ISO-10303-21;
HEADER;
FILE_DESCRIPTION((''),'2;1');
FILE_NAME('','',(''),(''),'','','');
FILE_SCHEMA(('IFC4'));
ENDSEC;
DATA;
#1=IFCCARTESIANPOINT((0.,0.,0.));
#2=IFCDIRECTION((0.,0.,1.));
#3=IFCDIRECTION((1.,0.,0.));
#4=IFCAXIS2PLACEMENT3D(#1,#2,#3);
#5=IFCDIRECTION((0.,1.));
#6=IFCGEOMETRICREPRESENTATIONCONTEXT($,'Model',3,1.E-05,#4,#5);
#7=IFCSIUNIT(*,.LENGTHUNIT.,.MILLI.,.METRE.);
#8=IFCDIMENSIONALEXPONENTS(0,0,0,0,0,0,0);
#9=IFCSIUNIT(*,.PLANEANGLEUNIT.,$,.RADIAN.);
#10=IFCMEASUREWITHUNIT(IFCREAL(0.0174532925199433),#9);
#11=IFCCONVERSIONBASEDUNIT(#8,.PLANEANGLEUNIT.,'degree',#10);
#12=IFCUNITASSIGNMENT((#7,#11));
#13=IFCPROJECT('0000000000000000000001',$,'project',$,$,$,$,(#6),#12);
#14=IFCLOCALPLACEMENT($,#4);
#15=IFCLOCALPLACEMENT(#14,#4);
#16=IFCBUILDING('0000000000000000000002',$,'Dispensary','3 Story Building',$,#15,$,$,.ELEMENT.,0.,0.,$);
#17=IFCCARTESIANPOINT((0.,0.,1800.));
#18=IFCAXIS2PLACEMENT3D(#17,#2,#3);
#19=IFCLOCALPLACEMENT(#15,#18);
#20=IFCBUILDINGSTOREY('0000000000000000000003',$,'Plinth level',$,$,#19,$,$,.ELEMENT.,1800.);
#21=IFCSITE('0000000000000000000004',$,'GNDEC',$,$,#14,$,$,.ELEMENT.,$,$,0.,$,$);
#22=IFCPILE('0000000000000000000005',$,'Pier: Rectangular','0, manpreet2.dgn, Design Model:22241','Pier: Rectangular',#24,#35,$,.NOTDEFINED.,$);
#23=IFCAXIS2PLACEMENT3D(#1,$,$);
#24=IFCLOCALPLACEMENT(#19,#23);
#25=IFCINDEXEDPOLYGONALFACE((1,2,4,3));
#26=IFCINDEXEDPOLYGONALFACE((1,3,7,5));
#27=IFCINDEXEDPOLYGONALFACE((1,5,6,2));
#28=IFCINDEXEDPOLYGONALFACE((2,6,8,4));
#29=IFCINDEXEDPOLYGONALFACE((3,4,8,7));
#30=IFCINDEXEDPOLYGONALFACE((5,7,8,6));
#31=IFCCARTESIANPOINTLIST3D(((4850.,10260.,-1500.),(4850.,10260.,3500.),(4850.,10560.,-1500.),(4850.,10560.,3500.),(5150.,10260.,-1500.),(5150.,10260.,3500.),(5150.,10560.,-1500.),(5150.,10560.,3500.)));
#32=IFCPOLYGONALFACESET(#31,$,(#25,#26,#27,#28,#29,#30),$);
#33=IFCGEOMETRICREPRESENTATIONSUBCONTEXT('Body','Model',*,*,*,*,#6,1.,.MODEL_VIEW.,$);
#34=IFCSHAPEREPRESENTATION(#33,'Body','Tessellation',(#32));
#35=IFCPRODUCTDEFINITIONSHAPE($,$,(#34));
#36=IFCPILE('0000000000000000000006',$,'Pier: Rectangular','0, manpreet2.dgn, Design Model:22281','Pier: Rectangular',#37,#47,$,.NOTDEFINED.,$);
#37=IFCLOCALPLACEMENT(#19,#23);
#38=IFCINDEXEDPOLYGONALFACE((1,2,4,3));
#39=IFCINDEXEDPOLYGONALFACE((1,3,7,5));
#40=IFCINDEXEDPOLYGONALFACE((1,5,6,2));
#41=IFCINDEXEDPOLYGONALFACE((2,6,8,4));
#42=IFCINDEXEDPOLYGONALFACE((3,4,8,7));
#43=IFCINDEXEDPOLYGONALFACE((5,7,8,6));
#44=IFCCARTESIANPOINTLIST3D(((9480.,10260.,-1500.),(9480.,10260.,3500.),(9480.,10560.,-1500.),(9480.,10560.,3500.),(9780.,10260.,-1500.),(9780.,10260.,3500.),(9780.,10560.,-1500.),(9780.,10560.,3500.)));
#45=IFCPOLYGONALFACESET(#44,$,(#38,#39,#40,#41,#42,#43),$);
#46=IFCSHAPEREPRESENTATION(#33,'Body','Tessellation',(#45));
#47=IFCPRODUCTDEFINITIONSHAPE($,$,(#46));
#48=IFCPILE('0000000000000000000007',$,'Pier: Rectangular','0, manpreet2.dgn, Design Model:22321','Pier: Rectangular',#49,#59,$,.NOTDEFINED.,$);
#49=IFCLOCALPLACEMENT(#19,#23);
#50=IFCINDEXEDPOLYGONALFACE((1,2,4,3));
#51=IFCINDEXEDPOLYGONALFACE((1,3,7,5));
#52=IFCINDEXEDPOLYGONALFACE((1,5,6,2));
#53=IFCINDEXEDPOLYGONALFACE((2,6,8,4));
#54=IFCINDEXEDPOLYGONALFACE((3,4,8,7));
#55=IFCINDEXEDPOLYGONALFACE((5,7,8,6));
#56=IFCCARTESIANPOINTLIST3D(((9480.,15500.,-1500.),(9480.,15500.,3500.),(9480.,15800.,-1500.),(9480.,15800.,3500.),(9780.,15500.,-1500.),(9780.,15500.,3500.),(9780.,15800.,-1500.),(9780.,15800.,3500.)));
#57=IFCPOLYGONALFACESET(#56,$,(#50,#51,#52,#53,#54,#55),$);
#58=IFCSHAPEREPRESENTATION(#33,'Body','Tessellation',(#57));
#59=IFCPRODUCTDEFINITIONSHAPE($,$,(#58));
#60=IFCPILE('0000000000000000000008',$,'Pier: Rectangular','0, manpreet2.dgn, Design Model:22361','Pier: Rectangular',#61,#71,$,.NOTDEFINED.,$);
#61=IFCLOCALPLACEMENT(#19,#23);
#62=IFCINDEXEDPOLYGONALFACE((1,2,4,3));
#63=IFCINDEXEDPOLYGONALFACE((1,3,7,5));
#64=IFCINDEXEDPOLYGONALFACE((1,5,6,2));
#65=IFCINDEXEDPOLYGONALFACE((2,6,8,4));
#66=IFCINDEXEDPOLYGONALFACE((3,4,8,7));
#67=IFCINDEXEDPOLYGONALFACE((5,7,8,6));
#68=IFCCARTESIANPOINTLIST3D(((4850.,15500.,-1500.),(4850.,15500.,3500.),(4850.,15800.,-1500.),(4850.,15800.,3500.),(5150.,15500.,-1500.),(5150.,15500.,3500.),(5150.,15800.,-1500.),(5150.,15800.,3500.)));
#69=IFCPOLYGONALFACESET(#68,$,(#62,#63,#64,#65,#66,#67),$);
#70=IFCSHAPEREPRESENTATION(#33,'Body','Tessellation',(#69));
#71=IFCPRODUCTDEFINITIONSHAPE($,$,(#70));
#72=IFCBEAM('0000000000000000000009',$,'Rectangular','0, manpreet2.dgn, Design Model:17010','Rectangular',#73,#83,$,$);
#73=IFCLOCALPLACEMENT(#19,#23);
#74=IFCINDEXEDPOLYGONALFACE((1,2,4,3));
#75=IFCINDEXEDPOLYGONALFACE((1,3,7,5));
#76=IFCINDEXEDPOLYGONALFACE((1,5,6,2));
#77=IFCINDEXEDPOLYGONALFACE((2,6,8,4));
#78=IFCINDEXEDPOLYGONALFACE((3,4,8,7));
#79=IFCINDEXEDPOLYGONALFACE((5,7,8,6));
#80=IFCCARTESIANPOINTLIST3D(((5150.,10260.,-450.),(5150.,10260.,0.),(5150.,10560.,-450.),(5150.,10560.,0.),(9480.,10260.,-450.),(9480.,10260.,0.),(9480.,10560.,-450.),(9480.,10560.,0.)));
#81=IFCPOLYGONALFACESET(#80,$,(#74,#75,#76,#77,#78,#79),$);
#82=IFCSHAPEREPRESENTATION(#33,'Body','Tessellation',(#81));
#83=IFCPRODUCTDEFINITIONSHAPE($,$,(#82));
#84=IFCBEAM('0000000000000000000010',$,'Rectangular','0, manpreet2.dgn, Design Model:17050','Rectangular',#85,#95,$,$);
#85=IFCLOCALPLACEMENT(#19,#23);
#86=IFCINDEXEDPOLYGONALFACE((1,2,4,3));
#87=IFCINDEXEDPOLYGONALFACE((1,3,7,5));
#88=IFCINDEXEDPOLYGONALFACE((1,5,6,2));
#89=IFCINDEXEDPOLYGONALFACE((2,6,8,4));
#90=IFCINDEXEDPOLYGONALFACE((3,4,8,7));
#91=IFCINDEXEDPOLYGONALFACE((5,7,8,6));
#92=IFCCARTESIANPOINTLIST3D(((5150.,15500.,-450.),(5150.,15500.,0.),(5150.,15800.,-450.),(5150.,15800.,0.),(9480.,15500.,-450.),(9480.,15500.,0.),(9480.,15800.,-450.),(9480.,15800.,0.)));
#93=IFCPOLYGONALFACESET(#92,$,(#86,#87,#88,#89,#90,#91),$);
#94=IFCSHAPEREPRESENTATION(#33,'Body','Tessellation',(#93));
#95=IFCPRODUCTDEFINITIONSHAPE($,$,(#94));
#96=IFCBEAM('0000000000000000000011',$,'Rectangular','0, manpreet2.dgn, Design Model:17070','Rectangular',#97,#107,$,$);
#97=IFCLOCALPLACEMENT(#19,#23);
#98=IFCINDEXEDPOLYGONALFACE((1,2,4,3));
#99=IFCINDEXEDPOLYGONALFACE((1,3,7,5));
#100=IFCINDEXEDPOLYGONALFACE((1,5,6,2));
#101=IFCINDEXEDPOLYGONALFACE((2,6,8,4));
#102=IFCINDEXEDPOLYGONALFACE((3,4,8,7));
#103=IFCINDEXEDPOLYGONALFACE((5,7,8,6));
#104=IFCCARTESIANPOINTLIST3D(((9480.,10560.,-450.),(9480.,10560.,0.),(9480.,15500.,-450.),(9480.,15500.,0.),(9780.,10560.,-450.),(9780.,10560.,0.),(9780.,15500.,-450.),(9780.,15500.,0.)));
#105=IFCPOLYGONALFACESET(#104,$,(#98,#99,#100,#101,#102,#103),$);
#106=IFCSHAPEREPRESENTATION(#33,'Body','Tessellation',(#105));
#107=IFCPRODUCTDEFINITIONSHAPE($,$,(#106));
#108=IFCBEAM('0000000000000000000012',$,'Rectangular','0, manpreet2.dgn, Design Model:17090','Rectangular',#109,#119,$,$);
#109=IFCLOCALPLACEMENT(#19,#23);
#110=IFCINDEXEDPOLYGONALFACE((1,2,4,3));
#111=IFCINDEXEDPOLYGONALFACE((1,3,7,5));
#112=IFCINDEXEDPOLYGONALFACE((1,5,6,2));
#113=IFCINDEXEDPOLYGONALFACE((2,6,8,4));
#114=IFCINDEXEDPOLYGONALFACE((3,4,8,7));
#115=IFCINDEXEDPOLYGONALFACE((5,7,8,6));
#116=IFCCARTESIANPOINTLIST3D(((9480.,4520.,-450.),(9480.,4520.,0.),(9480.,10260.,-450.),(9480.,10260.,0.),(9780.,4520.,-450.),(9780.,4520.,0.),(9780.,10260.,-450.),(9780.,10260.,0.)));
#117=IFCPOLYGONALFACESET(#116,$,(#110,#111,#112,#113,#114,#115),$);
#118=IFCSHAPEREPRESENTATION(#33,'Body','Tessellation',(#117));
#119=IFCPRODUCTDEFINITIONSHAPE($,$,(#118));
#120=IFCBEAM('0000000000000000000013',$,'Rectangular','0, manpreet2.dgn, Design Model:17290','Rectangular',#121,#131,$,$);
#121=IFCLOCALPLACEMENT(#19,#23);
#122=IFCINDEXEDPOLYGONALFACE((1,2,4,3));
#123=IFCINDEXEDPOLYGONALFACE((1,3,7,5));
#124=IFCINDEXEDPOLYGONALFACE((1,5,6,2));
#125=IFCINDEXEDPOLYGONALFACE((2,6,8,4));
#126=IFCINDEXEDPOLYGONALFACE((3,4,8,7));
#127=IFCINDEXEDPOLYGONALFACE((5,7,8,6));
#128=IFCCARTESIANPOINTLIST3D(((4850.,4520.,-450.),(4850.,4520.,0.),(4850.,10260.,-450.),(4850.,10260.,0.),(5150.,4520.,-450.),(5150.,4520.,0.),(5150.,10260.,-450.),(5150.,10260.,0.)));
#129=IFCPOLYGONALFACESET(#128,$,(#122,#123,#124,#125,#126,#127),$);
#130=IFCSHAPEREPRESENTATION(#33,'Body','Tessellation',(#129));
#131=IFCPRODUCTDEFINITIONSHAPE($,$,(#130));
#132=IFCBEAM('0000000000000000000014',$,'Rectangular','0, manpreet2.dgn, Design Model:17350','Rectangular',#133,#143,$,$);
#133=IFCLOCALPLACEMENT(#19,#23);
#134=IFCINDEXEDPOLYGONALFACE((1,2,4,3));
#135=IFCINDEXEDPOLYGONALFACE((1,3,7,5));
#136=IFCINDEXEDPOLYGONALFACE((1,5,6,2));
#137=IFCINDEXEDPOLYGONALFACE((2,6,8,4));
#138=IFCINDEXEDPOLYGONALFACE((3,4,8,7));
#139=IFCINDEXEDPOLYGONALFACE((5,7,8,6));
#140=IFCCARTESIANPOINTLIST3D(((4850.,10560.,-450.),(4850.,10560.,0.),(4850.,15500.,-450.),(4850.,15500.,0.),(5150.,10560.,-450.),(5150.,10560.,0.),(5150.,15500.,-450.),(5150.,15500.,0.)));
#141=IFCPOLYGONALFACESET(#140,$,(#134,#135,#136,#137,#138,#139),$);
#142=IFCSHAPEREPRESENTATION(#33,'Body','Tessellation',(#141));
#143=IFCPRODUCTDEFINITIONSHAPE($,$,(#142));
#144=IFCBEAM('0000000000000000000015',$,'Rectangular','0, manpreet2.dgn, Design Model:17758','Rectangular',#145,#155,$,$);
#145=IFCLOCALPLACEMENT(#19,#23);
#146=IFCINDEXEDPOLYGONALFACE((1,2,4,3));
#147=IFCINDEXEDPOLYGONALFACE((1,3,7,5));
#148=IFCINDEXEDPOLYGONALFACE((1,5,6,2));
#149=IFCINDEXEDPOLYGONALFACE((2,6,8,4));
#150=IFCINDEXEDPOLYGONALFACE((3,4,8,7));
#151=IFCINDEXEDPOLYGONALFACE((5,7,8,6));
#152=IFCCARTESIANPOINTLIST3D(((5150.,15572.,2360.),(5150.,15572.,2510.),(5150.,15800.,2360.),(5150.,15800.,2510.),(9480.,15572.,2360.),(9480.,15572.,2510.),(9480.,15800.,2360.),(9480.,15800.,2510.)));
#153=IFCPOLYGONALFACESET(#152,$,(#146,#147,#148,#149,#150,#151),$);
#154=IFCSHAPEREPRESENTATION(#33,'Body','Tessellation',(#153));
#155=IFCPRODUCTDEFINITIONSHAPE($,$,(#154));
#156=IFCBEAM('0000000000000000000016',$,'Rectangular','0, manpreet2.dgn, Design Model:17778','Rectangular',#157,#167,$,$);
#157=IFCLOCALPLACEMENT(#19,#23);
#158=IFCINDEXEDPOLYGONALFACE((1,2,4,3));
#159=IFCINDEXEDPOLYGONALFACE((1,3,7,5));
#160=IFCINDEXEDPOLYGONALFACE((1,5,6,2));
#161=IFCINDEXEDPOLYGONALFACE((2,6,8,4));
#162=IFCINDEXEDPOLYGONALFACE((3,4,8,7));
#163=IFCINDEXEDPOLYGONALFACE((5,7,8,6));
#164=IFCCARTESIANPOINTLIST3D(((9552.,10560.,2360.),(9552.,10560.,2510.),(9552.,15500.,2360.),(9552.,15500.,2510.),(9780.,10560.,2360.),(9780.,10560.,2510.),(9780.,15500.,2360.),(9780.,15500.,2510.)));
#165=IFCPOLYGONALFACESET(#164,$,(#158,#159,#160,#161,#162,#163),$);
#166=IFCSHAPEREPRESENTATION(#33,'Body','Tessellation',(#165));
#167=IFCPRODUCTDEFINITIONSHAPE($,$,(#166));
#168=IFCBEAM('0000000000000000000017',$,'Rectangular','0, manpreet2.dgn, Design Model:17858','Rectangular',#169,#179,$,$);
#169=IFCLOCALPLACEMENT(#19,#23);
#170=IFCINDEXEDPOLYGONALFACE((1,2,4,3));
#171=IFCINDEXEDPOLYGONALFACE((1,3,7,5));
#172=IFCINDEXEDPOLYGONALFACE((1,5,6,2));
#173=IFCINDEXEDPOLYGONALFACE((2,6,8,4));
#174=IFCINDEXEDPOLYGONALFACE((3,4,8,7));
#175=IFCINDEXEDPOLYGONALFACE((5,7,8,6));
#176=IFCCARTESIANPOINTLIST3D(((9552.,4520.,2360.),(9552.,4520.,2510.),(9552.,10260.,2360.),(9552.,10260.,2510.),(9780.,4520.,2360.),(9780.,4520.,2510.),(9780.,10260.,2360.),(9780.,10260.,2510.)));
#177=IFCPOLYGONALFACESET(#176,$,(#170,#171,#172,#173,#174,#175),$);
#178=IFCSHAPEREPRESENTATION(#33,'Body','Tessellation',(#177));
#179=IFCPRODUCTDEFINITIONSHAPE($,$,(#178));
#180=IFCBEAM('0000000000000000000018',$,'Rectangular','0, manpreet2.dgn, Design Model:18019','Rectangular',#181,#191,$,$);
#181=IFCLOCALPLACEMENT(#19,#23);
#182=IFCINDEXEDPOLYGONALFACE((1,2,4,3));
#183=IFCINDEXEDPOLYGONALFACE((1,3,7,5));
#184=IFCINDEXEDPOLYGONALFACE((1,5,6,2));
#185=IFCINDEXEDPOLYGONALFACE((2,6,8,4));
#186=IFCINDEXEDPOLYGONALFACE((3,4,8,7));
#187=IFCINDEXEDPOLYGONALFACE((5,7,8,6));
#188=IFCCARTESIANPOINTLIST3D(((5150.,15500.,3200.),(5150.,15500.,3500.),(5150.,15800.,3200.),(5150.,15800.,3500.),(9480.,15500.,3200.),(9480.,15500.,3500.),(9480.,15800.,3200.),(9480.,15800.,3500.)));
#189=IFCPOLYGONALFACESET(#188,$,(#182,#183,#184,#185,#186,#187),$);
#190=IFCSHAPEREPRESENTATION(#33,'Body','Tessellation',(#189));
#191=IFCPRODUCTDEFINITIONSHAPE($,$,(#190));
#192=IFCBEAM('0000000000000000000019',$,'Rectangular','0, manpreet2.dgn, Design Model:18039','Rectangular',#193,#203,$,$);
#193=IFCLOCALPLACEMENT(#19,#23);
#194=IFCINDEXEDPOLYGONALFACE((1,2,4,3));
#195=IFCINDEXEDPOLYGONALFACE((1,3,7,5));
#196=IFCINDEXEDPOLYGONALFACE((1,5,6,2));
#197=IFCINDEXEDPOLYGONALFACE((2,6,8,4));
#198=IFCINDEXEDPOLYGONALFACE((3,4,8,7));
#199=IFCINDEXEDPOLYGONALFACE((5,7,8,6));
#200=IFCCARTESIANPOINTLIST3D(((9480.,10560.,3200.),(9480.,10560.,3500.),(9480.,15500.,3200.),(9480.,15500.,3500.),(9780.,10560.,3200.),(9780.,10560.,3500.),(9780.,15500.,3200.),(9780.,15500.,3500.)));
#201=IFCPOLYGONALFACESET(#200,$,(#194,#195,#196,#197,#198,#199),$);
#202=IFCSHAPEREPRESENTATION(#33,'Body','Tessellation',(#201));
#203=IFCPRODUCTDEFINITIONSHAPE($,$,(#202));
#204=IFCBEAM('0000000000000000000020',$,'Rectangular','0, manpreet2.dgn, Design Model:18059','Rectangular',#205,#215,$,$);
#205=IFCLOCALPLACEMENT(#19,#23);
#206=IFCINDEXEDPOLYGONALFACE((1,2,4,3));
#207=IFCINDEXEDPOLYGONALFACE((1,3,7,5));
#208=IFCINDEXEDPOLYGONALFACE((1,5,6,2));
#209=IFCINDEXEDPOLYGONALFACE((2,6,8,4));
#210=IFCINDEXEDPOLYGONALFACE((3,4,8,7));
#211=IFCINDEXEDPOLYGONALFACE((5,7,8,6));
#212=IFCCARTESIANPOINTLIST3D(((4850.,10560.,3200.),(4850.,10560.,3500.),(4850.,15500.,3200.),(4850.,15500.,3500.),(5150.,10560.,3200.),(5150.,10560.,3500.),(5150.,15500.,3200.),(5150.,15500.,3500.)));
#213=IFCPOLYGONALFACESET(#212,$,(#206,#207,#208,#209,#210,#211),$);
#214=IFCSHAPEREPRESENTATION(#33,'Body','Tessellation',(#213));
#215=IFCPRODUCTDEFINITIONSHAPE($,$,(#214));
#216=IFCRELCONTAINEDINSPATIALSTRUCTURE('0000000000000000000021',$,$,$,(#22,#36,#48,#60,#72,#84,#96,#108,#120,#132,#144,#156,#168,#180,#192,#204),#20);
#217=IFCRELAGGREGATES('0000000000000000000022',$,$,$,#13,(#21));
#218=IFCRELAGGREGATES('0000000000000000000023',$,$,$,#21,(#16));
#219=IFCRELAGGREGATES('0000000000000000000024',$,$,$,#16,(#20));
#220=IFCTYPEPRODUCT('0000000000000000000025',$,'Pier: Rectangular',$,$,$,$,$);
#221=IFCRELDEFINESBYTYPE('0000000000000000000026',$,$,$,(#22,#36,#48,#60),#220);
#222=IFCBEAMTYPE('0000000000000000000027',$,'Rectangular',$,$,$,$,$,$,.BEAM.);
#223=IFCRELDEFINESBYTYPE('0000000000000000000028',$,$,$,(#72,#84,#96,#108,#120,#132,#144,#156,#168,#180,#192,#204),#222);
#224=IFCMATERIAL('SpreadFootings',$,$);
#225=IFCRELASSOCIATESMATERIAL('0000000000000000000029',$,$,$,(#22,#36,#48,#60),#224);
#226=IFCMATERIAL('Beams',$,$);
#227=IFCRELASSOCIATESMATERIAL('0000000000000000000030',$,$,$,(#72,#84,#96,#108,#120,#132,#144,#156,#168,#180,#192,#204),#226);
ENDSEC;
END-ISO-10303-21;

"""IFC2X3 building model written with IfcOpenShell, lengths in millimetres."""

from ifc_helpers import new_model, entity, si_unit, converted_unit, direction, frame, frame_2d, origin_with_axes, place, context, subcontext, project, spatial, rectangle, extrude, material, type_object, element, save


model = new_model("IFC2X3")

# Units and contexts
model_context = context("Model", 3, precision=1e-05, world=origin_with_axes(), true_north=direction((0.0, 1.0)))
body_context = subcontext(model_context, "Body", "Model", "MODEL_VIEW", scale=1.0)
ifc_project = project(units=[si_unit("LENGTHUNIT", "METRE", prefix="MILLI"), converted_unit("PLANEANGLEUNIT", "degree", entity("IfcReal", 0.0174532925199433), si_unit("PLANEANGLEUNIT", "RADIAN"), dimensions=[0, 0, 0, 0, 0, 0, 0])], contexts=[model_context])

# Site, building, storey
site_placement = place(None, origin_with_axes())
site = spatial("IfcSite", under=ifc_project, at=site_placement, Name="GNDEC", CompositionType="ELEMENT", RefElevation=0.0)
building_placement = place(site_placement, origin_with_axes())
building = spatial("IfcBuilding", under=site, at=building_placement, Name="Dispensary", Description="3 Story Building", CompositionType="ELEMENT", ElevationOfRefHeight=0.0, ElevationOfTerrain=0.0)
storey_placement = place(building_placement, frame((0.0, 0.0, 1800.0), z_axis=(0.0, 0.0, 1.0), x_axis=(1.0, 0.0, 0.0)))
storey = spatial("IfcBuildingStorey", under=building, at=storey_placement, Name="Plinth level", CompositionType="ELEMENT", Elevation=1800.0)

# Piles
ifc_material_1 = material(Name="SpreadFootings")
type_product = type_object("IfcTypeProduct", Name="Pier: Rectangular")
for number, where, z_axis, x_axis, name, description in (
    (1, (4850.0, 10560.0, -1500.0), (0.0, 0.0, 1.0), (0.0, -1.0, 0.0), "Pier: Rectangular", "0, manpreet2.dgn, Design Model:22241"),
    (2, (9480.0, 10560.0, -1500.0), (0.0, 0.0, 1.0), (0.0, -1.0, 0.0), "Pier: Rectangular", "0, manpreet2.dgn, Design Model:22281"),
    (3, (9480.0, 15800.0, -1500.0), (0.0, 0.0, 1.0), (0.0, -1.0, 0.0), "Pier: Rectangular", "0, manpreet2.dgn, Design Model:22321"),
    (4, (4850.0, 15800.0, -1500.0), (0.0, 0.0, 1.0), (0.0, -1.0, 0.0), "Pier: Rectangular", "0, manpreet2.dgn, Design Model:22361"),
):
    element("IfcPile", number, at=place(storey_placement, frame(where, z_axis=z_axis, x_axis=x_axis)), inside=storey, type_object=type_product, material=ifc_material_1, Name=name, Description=description, ObjectType="Pier: Rectangular", PredefinedType="NOTDEFINED", context=body_context, shape_type="SweptSolid", body=[
        extrude(rectangle(XDim=300.0, YDim=300.0, at=frame_2d((150.0, 150.0), x_axis=(0.0, 1.0))), origin_with_axes(), (0.0, 0.0, 1.0), 5000.0),
    ])

# Beams
ifc_material_2 = material(Name="Beams")
beam_type = type_object("IfcBeamType", Name="Rectangular", PredefinedType="BEAM")
for number, where, z_axis, x_axis, name, description in (
    (5, (5150.0, 10560.0, -450.0), (1.0, 0.0, 0.0), (0.0, 0.0, 1.0), "Rectangular", "0, manpreet2.dgn, Design Model:17010"),
    (6, (5150.0, 15800.0, -450.0), (1.0, 0.0, 0.0), (0.0, 0.0, 1.0), "Rectangular", "0, manpreet2.dgn, Design Model:17050"),
):
    element("IfcBeam", number, at=place(storey_placement, frame(where, z_axis=z_axis, x_axis=x_axis)), inside=storey, type_object=beam_type, material=ifc_material_2, Name=name, Description=description, ObjectType="Rectangular", context=body_context, shape_type="SweptSolid", body=[
        extrude(rectangle(XDim=300.0, YDim=450.0, at=frame_2d((225.0, 150.0), x_axis=(0.0, 1.0))), origin_with_axes(), (0.0, 0.0, 1.0), 4330.0),
    ])
beam_1_placement = place(storey_placement, frame((9780.0, 15500.0, -450.0), z_axis=(0.0, -1.0, 0.0), x_axis=(0.0, 0.0, 1.0)))
element("IfcBeam", 7, at=beam_1_placement, inside=storey, type_object=beam_type, material=ifc_material_2, Name="Rectangular", Description="0, manpreet2.dgn, Design Model:17070", ObjectType="Rectangular", context=body_context, shape_type="SweptSolid", body=[
    extrude(rectangle(XDim=300.0, YDim=450.0, at=frame_2d((225.0, 150.0), x_axis=(0.0, 1.0))), origin_with_axes(), (0.0, 0.0, 1.0), 4940.0),
])
for number, where, z_axis, x_axis, name, description in (
    (8, (9780.0, 10260.0, -450.0), (0.0, -1.0, 0.0), (0.0, 0.0, 1.0), "Rectangular", "0, manpreet2.dgn, Design Model:17090"),
    (9, (5150.0, 10260.0, -450.0), (0.0, -1.0, 0.0), (0.0, 0.0, 1.0), "Rectangular", "0, manpreet2.dgn, Design Model:17290"),
):
    element("IfcBeam", number, at=place(storey_placement, frame(where, z_axis=z_axis, x_axis=x_axis)), inside=storey, type_object=beam_type, material=ifc_material_2, Name=name, Description=description, ObjectType="Rectangular", context=body_context, shape_type="SweptSolid", body=[
        extrude(rectangle(XDim=300.0, YDim=450.0, at=frame_2d((225.0, 150.0), x_axis=(0.0, 1.0))), origin_with_axes(), (0.0, 0.0, 1.0), 5740.0),
    ])
beam_2_placement = place(storey_placement, frame((5150.0, 15500.0, -450.0), z_axis=(0.0, -1.0, 0.0), x_axis=(0.0, 0.0, 1.0)))
element("IfcBeam", 10, at=beam_2_placement, inside=storey, type_object=beam_type, material=ifc_material_2, Name="Rectangular", Description="0, manpreet2.dgn, Design Model:17350", ObjectType="Rectangular", context=body_context, shape_type="SweptSolid", body=[
    extrude(rectangle(XDim=300.0, YDim=450.0, at=frame_2d((225.0, 150.0), x_axis=(0.0, 1.0))), origin_with_axes(), (0.0, 0.0, 1.0), 4940.0),
])
beam_3_placement = place(storey_placement, frame((5150.0, 15572.0, 2360.0), z_axis=(1.0, 0.0, 0.0), x_axis=(0.0, 1.0, 0.0)))
element("IfcBeam", 11, at=beam_3_placement, inside=storey, type_object=beam_type, material=ifc_material_2, Name="Rectangular", Description="0, manpreet2.dgn, Design Model:17758", ObjectType="Rectangular", context=body_context, shape_type="SweptSolid", body=[
    extrude(rectangle(XDim=150.0, YDim=228.0, at=frame_2d((114.0, 75.0), x_axis=(0.0, 1.0))), origin_with_axes(), (0.0, 0.0, 1.0), 4330.0),
])
beam_4_placement = place(storey_placement, frame((9552.0, 15500.0, 2360.0), z_axis=(0.0, -1.0, 0.0), x_axis=(1.0, 0.0, 0.0)))
element("IfcBeam", 12, at=beam_4_placement, inside=storey, type_object=beam_type, material=ifc_material_2, Name="Rectangular", Description="0, manpreet2.dgn, Design Model:17778", ObjectType="Rectangular", context=body_context, shape_type="SweptSolid", body=[
    extrude(rectangle(XDim=150.0, YDim=228.0, at=frame_2d((114.0, 75.0), x_axis=(0.0, 1.0))), origin_with_axes(), (0.0, 0.0, 1.0), 4940.0),
])
beam_5_placement = place(storey_placement, frame((9552.0, 10260.0, 2360.0), z_axis=(0.0, -1.0, 0.0), x_axis=(1.0, 0.0, 0.0)))
element("IfcBeam", 13, at=beam_5_placement, inside=storey, type_object=beam_type, material=ifc_material_2, Name="Rectangular", Description="0, manpreet2.dgn, Design Model:17858", ObjectType="Rectangular", context=body_context, shape_type="SweptSolid", body=[
    extrude(rectangle(XDim=150.0, YDim=228.0, at=frame_2d((114.0, 75.0), x_axis=(0.0, 1.0))), origin_with_axes(), (0.0, 0.0, 1.0), 5740.0),
])
beam_6_placement = place(storey_placement, frame((5150.0, 15500.0, 3200.0), z_axis=(1.0, 0.0, 0.0), x_axis=(0.0, 1.0, 0.0)))
element("IfcBeam", 14, at=beam_6_placement, inside=storey, type_object=beam_type, material=ifc_material_2, Name="Rectangular", Description="0, manpreet2.dgn, Design Model:18019", ObjectType="Rectangular", context=body_context, shape_type="SweptSolid", body=[
    extrude(rectangle(XDim=300.0, YDim=300.0, at=frame_2d((150.0, 150.0), x_axis=(0.0, 1.0))), origin_with_axes(), (0.0, 0.0, 1.0), 4330.0),
])
for number, where, z_axis, x_axis, name, description in (
    (15, (9480.0, 15500.0, 3200.0), (0.0, -1.0, 0.0), (1.0, 0.0, 0.0), "Rectangular", "0, manpreet2.dgn, Design Model:18039"),
    (16, (4850.0, 15500.0, 3200.0), (0.0, -1.0, 0.0), (1.0, 0.0, 0.0), "Rectangular", "0, manpreet2.dgn, Design Model:18059"),
):
    element("IfcBeam", number, at=place(storey_placement, frame(where, z_axis=z_axis, x_axis=x_axis)), inside=storey, type_object=beam_type, material=ifc_material_2, Name=name, Description=description, ObjectType="Rectangular", context=body_context, shape_type="SweptSolid", body=[
        extrude(rectangle(XDim=300.0, YDim=300.0, at=frame_2d((150.0, 150.0), x_axis=(0.0, 1.0))), origin_with_axes(), (0.0, 0.0, 1.0), 4940.0),
    ])

save(model, "model.ifc")
